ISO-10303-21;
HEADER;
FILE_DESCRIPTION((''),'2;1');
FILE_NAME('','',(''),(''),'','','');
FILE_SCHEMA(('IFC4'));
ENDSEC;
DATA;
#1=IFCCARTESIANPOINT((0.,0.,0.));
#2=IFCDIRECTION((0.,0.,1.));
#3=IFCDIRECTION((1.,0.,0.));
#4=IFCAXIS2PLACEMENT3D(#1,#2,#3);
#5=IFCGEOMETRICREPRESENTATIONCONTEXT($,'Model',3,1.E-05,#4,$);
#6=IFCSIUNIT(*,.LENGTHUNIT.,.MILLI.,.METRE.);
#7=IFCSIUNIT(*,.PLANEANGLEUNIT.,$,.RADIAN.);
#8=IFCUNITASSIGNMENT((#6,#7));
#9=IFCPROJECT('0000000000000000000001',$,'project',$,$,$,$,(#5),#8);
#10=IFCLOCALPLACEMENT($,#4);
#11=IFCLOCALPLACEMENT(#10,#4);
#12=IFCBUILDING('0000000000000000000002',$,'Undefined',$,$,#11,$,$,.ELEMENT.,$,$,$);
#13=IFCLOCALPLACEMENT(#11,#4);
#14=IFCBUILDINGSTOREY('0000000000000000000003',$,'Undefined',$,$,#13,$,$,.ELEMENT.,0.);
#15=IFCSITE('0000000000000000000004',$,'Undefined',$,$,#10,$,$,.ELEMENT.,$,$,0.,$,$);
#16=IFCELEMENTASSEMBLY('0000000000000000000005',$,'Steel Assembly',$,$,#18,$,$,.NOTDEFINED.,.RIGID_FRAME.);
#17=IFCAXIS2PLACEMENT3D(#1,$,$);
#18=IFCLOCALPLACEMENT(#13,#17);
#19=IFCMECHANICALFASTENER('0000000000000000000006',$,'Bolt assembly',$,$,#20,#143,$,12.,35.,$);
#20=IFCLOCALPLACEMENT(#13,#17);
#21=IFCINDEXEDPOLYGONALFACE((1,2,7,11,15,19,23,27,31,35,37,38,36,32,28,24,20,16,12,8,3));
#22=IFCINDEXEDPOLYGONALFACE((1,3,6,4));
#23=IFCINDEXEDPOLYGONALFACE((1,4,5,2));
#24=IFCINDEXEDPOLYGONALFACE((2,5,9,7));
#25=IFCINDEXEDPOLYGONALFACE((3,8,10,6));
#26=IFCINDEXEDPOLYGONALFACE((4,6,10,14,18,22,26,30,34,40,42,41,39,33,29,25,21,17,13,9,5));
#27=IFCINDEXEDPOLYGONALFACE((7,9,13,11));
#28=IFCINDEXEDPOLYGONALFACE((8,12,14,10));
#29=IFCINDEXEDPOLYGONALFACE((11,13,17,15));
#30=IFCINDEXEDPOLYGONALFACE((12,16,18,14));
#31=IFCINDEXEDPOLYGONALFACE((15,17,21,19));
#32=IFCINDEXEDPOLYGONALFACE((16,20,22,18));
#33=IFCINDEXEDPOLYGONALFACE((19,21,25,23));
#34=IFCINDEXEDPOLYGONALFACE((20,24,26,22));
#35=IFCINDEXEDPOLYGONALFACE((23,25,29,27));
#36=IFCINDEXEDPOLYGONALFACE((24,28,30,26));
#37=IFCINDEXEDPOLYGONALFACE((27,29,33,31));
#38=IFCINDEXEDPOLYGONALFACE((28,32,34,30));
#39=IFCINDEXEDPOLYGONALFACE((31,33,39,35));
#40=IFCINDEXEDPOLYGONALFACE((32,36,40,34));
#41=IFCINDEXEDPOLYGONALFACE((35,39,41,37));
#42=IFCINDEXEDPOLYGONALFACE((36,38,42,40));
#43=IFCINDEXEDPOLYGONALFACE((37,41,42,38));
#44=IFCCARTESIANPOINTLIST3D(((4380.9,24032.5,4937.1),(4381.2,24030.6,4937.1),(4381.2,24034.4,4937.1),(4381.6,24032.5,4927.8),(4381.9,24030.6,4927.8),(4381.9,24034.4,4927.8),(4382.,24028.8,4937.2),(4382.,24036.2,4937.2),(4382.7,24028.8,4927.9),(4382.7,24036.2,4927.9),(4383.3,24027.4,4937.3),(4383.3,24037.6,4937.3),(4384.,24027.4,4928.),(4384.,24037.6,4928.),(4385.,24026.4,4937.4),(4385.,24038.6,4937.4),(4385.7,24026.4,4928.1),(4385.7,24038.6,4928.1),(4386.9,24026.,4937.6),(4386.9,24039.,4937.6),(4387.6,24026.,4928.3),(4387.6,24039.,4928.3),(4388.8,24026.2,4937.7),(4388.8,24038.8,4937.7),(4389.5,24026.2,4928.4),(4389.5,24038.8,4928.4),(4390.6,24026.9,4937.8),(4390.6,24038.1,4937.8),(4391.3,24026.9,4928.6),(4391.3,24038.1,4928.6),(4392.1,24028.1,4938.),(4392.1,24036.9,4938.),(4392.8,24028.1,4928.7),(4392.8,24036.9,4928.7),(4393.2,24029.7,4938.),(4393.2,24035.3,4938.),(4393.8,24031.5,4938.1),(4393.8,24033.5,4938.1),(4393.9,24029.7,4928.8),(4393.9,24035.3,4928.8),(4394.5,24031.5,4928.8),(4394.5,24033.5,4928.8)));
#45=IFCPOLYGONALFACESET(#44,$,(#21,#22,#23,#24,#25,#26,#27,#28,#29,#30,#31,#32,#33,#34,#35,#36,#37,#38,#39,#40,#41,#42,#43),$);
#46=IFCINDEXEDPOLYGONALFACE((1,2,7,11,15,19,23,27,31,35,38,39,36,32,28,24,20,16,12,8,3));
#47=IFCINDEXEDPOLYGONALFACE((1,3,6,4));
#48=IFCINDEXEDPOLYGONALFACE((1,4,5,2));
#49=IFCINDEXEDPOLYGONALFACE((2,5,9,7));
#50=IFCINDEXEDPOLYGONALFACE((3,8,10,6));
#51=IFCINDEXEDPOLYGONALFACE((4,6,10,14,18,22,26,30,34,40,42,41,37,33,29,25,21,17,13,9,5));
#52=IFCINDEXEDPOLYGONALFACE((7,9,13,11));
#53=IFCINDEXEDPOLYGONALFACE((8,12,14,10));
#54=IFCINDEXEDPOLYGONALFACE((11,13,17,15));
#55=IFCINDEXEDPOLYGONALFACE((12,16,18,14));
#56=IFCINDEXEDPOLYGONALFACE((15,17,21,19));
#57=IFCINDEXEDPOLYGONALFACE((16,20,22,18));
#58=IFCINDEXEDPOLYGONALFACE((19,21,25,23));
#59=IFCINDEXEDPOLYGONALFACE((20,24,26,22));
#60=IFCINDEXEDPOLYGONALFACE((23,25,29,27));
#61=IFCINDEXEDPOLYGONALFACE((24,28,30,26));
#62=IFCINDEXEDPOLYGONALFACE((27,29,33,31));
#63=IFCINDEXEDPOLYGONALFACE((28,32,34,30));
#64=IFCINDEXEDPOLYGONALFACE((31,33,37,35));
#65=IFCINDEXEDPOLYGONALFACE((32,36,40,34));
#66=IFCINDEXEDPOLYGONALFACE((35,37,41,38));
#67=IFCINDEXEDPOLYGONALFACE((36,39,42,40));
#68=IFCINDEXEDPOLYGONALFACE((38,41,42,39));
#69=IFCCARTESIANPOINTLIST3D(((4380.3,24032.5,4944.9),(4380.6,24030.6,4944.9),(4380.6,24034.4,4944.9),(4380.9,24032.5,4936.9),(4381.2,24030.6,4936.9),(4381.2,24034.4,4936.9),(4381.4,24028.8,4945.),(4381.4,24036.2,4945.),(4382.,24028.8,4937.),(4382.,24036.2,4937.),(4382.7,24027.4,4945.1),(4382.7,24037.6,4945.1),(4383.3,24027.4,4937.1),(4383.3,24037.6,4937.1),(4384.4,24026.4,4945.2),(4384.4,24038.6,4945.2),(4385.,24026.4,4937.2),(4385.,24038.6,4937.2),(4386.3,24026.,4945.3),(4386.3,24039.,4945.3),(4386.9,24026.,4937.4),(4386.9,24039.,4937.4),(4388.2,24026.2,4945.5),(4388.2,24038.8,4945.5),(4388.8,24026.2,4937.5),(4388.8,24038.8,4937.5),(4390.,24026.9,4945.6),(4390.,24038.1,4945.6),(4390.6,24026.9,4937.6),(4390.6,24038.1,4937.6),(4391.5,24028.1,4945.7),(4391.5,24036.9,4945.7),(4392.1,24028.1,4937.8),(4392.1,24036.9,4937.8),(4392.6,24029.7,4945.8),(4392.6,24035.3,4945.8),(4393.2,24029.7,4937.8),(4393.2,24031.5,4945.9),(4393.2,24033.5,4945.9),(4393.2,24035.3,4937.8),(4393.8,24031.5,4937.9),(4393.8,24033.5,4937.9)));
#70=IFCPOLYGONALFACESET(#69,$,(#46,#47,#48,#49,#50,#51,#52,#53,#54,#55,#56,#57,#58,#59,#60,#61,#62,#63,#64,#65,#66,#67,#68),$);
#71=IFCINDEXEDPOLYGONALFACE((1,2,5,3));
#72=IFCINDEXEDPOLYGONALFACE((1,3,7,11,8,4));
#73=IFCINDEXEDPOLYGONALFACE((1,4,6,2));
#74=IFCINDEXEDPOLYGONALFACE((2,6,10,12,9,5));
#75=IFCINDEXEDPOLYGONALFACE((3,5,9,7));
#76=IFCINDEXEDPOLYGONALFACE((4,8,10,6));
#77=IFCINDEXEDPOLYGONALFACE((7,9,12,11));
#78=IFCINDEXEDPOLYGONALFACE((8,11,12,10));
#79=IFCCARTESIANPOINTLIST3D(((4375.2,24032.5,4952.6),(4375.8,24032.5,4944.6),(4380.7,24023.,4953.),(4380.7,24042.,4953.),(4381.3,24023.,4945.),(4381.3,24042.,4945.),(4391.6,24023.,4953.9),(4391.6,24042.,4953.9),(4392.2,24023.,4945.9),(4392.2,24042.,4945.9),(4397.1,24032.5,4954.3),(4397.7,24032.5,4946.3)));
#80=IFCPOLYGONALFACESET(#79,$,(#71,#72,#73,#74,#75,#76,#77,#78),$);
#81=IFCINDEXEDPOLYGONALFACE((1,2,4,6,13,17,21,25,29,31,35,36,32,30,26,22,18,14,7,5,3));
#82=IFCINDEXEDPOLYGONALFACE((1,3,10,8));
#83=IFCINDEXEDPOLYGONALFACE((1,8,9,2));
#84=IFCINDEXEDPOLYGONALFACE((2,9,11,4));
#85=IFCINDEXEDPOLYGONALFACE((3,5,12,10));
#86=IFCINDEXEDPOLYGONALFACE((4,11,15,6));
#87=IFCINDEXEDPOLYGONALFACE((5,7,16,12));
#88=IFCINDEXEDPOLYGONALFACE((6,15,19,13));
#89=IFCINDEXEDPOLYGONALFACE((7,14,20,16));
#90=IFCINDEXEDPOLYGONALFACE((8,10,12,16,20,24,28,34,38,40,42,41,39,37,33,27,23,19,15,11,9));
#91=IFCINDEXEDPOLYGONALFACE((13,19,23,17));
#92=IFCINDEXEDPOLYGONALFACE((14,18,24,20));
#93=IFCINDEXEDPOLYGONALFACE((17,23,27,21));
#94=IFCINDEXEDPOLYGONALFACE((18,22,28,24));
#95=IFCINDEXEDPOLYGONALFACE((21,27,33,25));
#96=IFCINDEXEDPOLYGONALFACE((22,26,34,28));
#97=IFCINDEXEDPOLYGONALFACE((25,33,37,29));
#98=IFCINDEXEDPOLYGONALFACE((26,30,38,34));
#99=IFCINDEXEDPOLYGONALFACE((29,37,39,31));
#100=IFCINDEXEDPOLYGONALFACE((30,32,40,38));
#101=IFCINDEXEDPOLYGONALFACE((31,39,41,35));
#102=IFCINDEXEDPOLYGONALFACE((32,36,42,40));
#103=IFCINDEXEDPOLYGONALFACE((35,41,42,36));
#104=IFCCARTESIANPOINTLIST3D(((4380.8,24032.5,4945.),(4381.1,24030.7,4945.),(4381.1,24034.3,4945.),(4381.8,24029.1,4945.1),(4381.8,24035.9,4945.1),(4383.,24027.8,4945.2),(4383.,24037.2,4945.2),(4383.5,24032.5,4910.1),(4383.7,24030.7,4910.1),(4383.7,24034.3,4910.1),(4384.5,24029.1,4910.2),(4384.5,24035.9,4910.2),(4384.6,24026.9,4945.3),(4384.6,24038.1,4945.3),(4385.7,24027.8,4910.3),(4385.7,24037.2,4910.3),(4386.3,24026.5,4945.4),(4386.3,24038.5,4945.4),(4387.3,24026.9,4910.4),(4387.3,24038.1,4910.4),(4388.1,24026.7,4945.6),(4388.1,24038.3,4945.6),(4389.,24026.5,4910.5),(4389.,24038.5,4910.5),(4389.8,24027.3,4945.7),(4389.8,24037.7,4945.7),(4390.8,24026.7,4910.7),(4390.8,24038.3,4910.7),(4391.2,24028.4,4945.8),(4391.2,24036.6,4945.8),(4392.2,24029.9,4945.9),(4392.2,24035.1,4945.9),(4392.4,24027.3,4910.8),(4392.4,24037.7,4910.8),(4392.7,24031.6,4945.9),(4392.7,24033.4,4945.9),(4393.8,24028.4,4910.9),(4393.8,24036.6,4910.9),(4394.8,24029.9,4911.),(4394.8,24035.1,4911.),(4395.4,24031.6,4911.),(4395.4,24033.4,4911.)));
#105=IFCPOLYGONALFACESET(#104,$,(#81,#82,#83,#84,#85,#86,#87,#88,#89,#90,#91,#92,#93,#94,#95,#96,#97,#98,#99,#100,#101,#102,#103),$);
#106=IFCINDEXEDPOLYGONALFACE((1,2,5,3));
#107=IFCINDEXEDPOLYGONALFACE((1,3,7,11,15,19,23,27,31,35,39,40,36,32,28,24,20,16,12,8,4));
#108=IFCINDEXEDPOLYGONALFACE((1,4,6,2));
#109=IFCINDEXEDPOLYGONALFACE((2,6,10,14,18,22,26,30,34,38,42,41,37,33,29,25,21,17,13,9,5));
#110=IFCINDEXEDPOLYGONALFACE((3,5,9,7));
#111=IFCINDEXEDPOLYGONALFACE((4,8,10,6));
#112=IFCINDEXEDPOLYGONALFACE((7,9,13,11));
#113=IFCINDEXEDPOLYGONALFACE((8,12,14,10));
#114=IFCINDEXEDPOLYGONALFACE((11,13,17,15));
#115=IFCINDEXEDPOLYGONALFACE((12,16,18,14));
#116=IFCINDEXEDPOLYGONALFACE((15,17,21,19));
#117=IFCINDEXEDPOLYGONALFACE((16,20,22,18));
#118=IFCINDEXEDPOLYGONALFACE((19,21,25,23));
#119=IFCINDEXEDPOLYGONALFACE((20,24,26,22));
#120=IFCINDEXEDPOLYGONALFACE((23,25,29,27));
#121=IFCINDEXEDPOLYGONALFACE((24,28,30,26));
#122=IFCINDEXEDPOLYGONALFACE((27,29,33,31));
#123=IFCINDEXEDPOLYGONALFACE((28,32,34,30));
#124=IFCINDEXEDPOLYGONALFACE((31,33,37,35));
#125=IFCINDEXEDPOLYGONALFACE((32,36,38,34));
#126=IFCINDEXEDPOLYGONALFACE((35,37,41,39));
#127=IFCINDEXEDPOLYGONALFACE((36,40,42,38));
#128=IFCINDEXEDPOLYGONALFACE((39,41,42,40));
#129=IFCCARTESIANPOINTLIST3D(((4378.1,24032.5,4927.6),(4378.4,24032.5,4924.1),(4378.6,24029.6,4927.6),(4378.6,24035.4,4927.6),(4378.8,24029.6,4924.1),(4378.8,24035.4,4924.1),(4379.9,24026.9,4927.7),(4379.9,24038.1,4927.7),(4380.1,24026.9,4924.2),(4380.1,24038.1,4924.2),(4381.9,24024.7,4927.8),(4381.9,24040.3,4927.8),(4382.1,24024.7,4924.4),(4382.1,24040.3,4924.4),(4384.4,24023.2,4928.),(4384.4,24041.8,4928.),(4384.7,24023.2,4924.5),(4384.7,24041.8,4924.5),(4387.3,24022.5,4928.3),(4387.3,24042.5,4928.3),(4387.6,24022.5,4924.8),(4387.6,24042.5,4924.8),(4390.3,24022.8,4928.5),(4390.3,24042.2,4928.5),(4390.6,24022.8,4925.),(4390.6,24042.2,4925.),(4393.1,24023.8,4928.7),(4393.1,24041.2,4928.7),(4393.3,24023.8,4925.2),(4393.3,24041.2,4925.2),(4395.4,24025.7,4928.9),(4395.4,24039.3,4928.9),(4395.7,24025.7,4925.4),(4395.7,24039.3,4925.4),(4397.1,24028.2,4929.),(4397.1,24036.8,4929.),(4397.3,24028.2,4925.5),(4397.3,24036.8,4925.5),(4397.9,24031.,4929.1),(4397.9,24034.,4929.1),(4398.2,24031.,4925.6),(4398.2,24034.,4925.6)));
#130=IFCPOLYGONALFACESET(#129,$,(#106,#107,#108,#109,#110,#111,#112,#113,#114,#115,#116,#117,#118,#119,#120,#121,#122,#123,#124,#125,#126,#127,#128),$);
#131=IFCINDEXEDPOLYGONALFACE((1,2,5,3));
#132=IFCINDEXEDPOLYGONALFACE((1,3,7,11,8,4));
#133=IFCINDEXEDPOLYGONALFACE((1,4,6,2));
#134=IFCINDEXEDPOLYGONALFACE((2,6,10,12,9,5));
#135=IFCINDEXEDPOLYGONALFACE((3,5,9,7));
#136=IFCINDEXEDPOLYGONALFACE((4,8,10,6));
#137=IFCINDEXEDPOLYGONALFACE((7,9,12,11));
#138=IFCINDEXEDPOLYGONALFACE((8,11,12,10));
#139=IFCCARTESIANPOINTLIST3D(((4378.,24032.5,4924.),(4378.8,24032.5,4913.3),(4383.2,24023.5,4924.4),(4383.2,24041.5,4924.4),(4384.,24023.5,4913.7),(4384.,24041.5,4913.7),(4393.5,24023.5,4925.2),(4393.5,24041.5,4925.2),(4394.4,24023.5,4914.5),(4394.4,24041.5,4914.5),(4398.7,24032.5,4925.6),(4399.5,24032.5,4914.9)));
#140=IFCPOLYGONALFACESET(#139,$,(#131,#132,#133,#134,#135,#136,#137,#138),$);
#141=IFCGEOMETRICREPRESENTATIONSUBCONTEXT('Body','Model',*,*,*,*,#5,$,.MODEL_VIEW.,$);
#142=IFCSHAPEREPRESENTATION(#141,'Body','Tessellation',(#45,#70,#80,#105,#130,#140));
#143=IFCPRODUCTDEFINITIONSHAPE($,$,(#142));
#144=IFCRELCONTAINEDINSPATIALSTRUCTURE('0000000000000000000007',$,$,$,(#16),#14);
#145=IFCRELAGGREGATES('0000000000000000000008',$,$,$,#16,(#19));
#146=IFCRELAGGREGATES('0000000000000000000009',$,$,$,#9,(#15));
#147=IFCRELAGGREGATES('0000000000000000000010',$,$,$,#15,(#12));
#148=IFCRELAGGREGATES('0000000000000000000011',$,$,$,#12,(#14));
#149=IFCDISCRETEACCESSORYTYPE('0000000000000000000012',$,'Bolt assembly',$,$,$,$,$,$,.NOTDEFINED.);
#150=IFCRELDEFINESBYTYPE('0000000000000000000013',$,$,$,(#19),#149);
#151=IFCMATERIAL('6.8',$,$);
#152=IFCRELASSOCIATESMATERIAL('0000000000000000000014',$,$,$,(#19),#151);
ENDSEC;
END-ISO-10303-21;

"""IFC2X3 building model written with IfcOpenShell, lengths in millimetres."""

from ifc_helpers import new_model, si_unit, frame, origin_with_axes, origin_2d_with_axis, place, context, subcontext, project, spatial, polyline, circle, outline, extrude, source, transform, mapped, material, type_object, element, aggregate, save


model = new_model("IFC2X3")

# Units and contexts
model_context = context("Model", 3, precision=1e-05, world=origin_with_axes())
body_context = subcontext(model_context, "Body", "Model", "MODEL_VIEW")
ifc_project = project(units=[si_unit("LENGTHUNIT", "METRE", prefix="MILLI"), si_unit("PLANEANGLEUNIT", "RADIAN")], contexts=[model_context])

# Site, building, storey
site_placement = place(None, origin_with_axes())
site = spatial("IfcSite", under=ifc_project, at=site_placement, Name="Undefined", CompositionType="ELEMENT", RefElevation=0.0)
building_placement = place(site_placement, origin_with_axes())
building = spatial("IfcBuilding", under=site, at=building_placement, Name="Undefined", CompositionType="ELEMENT")
storey_placement = place(building_placement, origin_with_axes())
storey = spatial("IfcBuildingStorey", under=building, at=storey_placement, Name="Undefined", CompositionType="ELEMENT", Elevation=0.0)

# Shared definitions
ifc_material_1 = material(Name="6.8")
discrete_accessory_type_1 = type_object("IfcDiscreteAccessoryType", Name="Bolt assembly")

# Element assembly, mechanical fastener
assembly_1_placement = place(storey_placement, origin_with_axes())
assembly_1 = element("IfcElementAssembly", 1, at=assembly_1_placement, inside=storey, Name="Steel Assembly", AssemblyPlace="NOTDEFINED", PredefinedType="RIGID_FRAME")
shared_shape_1 = source(origin_with_axes(), body_context, "Body", "SweptSolid", [
    extrude(circle(Radius=6.5, at=origin_2d_with_axis()), frame((0.0, -0.1, 0.0), z_axis=(0.0, 1.0, 0.0), x_axis=(1.0, 0.0, 0.0)), (0.0, 0.0, 1.0), 9.3),
    extrude(circle(Radius=6.5, at=origin_2d_with_axis()), frame((0.0, -7.9, 0.0), z_axis=(0.0, 1.0, 0.0), x_axis=(1.0, 0.0, 0.0)), (0.0, 0.0, 1.0), 8.0),
    extrude(outline(polyline([(11.0, 0.0), (5.5, 9.5), (-5.5, 9.5), (-11.0, 0.0), (-5.5, -9.5), (5.5, -9.5), (11.0, 0.0)])), frame((0.0, -16.0, 0.0), z_axis=(0.0, 1.0, 0.0), x_axis=(1.0, 0.0, 0.0)), (0.0, 0.0, 1.0), 8.0),
    extrude(circle(Radius=6.0, at=origin_2d_with_axis()), frame((0.0, -8.0, 0.0), z_axis=(0.0, 1.0, 0.0), x_axis=(1.0, 0.0, 0.0)), (0.0, 0.0, 1.0), 35.0),
    extrude(circle(Radius=10.0, at=origin_2d_with_axis()), frame((0.0, 9.2, 0.0), z_axis=(0.0, 1.0, 0.0), x_axis=(1.0, 0.0, 0.0)), (0.0, 0.0, 1.0), 3.5),
    extrude(outline(polyline([(10.4, 0.0), (5.2, 9.0), (-5.2, 9.0), (-10.4, 0.0), (-5.2, -9.0), (5.2, -9.0), (10.4, 0.0)])), frame((0.0, 12.7, 0.0), z_axis=(0.0, 1.0, 0.0), x_axis=(1.0, 0.0, 0.0)), (0.0, 0.0, 1.0), 10.8),
])
mechanical_fastener_1_placement = place(assembly_1_placement, frame((4387.4, 24032.5, 4937.5), z_axis=(0.0, -1.0, 0.0), x_axis=(-0.997054, 0.0, -0.076696)))
mechanical_fastener_1 = element("IfcMechanicalFastener", 2, at=mechanical_fastener_1_placement, type_object=discrete_accessory_type_1, material=ifc_material_1, Name="Bolt assembly", NominalDiameter=12.0, NominalLength=35.0, context=body_context, shape_type="MappedRepresentation", body=[
    mapped(shared_shape_1, transform((0.0, 0.0, 0.0))),
])
aggregate(assembly_1, [mechanical_fastener_1])

save(model, "model.ifc")
